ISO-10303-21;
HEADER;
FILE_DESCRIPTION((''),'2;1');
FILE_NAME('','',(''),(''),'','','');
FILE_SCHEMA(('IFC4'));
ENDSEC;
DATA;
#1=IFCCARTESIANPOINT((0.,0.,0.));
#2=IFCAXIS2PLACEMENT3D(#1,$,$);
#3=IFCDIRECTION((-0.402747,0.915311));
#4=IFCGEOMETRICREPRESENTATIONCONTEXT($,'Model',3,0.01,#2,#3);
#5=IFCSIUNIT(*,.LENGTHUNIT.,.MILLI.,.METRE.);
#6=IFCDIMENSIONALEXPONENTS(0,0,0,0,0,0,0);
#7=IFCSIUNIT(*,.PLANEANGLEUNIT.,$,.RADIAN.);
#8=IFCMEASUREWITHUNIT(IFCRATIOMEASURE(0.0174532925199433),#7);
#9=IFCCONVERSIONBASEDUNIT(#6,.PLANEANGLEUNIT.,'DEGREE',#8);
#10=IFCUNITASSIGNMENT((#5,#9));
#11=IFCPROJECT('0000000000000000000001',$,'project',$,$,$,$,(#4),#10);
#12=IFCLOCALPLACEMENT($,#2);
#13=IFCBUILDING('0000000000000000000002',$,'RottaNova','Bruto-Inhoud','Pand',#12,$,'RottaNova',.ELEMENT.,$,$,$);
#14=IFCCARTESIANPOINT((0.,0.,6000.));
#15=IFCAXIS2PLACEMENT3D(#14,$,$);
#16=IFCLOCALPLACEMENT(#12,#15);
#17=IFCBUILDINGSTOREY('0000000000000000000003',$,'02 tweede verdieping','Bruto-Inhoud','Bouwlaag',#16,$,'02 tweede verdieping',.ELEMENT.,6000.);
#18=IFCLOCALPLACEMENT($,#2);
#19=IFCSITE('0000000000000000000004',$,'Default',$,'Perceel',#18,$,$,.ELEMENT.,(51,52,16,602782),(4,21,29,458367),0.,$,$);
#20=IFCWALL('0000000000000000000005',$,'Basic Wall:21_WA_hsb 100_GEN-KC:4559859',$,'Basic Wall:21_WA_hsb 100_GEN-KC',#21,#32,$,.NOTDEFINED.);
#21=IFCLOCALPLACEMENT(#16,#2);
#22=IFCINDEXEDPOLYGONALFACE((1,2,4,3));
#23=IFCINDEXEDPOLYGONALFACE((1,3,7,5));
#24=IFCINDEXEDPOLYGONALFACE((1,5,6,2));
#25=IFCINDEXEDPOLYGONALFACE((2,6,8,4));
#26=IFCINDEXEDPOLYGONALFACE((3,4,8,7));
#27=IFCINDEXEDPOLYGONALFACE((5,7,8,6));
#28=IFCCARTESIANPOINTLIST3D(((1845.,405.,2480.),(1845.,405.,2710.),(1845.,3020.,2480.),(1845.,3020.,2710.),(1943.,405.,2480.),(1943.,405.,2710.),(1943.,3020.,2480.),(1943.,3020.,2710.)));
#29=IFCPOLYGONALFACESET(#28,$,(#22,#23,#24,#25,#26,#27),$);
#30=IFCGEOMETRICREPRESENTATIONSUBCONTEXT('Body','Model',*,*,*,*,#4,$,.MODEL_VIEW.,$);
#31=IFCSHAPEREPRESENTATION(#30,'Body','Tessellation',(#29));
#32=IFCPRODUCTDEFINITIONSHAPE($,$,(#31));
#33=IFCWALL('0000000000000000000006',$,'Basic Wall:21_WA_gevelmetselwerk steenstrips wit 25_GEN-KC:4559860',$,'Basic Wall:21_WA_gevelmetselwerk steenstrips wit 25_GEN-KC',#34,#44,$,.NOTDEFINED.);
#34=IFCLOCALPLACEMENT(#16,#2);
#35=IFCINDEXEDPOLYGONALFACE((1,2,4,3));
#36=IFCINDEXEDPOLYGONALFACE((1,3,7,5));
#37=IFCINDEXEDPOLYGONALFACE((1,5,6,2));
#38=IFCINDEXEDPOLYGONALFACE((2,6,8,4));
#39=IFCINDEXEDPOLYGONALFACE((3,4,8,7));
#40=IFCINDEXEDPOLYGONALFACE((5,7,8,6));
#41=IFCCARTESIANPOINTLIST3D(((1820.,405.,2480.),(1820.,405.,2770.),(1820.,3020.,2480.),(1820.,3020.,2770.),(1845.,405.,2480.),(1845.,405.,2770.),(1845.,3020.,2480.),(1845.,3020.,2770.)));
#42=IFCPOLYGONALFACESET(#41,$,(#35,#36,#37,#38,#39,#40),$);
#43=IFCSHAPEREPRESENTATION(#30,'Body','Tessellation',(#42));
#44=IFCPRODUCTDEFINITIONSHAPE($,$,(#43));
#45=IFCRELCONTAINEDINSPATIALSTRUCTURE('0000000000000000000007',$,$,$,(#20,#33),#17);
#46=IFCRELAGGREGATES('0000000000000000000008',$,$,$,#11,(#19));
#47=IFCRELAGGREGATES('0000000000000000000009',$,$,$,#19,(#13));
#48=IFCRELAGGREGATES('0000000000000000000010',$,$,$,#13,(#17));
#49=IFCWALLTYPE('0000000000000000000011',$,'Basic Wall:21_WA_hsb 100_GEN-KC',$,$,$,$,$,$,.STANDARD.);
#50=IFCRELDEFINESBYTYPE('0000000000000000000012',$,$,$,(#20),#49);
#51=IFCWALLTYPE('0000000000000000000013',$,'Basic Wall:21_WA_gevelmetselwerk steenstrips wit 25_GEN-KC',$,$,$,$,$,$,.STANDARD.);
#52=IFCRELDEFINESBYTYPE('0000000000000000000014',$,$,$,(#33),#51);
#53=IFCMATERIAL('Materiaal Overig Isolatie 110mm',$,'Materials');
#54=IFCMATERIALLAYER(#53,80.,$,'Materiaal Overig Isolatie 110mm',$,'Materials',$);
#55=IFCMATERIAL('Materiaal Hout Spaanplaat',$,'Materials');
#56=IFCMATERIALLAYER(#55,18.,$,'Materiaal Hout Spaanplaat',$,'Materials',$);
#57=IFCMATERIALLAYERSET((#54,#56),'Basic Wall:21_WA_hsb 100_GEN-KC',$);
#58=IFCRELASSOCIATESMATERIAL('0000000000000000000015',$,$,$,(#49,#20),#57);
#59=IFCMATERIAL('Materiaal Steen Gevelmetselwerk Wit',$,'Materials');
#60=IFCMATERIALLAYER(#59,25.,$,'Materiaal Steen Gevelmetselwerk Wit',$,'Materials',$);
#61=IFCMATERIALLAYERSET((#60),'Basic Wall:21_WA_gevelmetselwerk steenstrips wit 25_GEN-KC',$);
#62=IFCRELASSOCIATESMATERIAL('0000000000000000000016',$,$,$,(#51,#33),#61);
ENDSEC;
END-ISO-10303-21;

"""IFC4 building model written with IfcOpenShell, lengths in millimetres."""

from ifc_helpers import new_model, entity, si_unit, converted_unit, direction, frame, frame_2d, origin, place, context, subcontext, project, spatial, rectangle, extrude, material, layer, layer_set, type_object, element, save


model = new_model("IFC4")

# Units and contexts
model_context = context("Model", 3, precision=0.01, world=origin(), true_north=direction((-0.402747, 0.915311)))
body_context = subcontext(model_context, "Body", "Model", "MODEL_VIEW")
ifc_project = project(units=[si_unit("LENGTHUNIT", "METRE", prefix="MILLI"), converted_unit("PLANEANGLEUNIT", "DEGREE", entity("IfcRatioMeasure", 0.0174532925199433), si_unit("PLANEANGLEUNIT", "RADIAN"), dimensions=[0, 0, 0, 0, 0, 0, 0])], contexts=[model_context])

# Site, building, storey
site_placement = place(None, origin())
site = spatial("IfcSite", under=ifc_project, at=site_placement, Name="Default", ObjectType="Perceel", CompositionType="ELEMENT", RefLatitude=(51, 52, 16, 602782), RefLongitude=(4, 21, 29, 458367), RefElevation=0.0)
building_placement = place(None, origin())
building = spatial("IfcBuilding", under=site, at=building_placement, Name="RottaNova", Description="Bruto-Inhoud", ObjectType="Pand", LongName="RottaNova", CompositionType="ELEMENT")
storey_placement = place(building_placement, frame((0.0, 0.0, 6000.0)))
storey = spatial("IfcBuildingStorey", under=building, at=storey_placement, Name="02 tweede verdieping", Description="Bruto-Inhoud", ObjectType="Bouwlaag", LongName="02 tweede verdieping", CompositionType="ELEMENT", Elevation=6000.0)

# Walls
ifc_material_1 = material(Name="Materiaal Steen Gevelmetselwerk Wit", Category="Materials")
ifc_material_2 = material(Name="Materiaal Overig Isolatie 110mm", Category="Materials")
ifc_layer_1 = layer(ifc_material_2, 80.0, Name="Materiaal Overig Isolatie 110mm", Category="Materials")
ifc_material_3 = material(Name="Materiaal Hout Spaanplaat", Category="Materials")
ifc_layer_2 = layer(ifc_material_3, 18.0, Name="Materiaal Hout Spaanplaat", Category="Materials")
ifc_layer_set_1 = layer_set([ifc_layer_1, ifc_layer_2], Name="Basic Wall:21_WA_hsb 100_GEN-KC")
wall_type_1 = type_object("IfcWallType", Name="Basic Wall:21_WA_hsb 100_GEN-KC", PredefinedType="STANDARD", material=ifc_layer_set_1)
wall_1_placement = place(storey_placement, frame((1894.0, 3020.0, 2480.0), z_axis=(0.0, 0.0, 1.0), x_axis=(0.0, -1.0, 0.0)))
element("IfcWall", 1, at=wall_1_placement, inside=storey, type_object=wall_type_1, material=ifc_layer_set_1, Name="Basic Wall:21_WA_hsb 100_GEN-KC:4559859", ObjectType="Basic Wall:21_WA_hsb 100_GEN-KC", PredefinedType="NOTDEFINED", context=body_context, shape_type="SweptSolid", body=[
    extrude(rectangle(XDim=2615.0, YDim=98.0, at=frame_2d((1307.5, 0.0), x_axis=(-1.0, 0.0))), origin(), (0.0, 0.0, 1.0), 230.0),
])
ifc_layer_3 = layer(ifc_material_1, 25.0, Name="Materiaal Steen Gevelmetselwerk Wit", Category="Materials")
ifc_layer_set_2 = layer_set([ifc_layer_3], Name="Basic Wall:21_WA_gevelmetselwerk steenstrips wit 25_GEN-KC")
wall_type_2 = type_object("IfcWallType", Name="Basic Wall:21_WA_gevelmetselwerk steenstrips wit 25_GEN-KC", PredefinedType="STANDARD", material=ifc_layer_set_2)
wall_2_placement = place(storey_placement, frame((1832.5, 405.0, 2480.0), z_axis=(0.0, 0.0, 1.0), x_axis=(0.0, 1.0, 0.0)))
element("IfcWall", 2, at=wall_2_placement, inside=storey, type_object=wall_type_2, material=ifc_layer_set_2, Name="Basic Wall:21_WA_gevelmetselwerk steenstrips wit 25_GEN-KC:4559860", ObjectType="Basic Wall:21_WA_gevelmetselwerk steenstrips wit 25_GEN-KC", PredefinedType="NOTDEFINED", context=body_context, shape_type="SweptSolid", body=[
    extrude(rectangle(XDim=2615.0, YDim=25.0, at=frame_2d((1307.5, 0.0), x_axis=(-1.0, 0.0))), origin(), (0.0, 0.0, 1.0), 290.0),
])

save(model, "model.ifc")
